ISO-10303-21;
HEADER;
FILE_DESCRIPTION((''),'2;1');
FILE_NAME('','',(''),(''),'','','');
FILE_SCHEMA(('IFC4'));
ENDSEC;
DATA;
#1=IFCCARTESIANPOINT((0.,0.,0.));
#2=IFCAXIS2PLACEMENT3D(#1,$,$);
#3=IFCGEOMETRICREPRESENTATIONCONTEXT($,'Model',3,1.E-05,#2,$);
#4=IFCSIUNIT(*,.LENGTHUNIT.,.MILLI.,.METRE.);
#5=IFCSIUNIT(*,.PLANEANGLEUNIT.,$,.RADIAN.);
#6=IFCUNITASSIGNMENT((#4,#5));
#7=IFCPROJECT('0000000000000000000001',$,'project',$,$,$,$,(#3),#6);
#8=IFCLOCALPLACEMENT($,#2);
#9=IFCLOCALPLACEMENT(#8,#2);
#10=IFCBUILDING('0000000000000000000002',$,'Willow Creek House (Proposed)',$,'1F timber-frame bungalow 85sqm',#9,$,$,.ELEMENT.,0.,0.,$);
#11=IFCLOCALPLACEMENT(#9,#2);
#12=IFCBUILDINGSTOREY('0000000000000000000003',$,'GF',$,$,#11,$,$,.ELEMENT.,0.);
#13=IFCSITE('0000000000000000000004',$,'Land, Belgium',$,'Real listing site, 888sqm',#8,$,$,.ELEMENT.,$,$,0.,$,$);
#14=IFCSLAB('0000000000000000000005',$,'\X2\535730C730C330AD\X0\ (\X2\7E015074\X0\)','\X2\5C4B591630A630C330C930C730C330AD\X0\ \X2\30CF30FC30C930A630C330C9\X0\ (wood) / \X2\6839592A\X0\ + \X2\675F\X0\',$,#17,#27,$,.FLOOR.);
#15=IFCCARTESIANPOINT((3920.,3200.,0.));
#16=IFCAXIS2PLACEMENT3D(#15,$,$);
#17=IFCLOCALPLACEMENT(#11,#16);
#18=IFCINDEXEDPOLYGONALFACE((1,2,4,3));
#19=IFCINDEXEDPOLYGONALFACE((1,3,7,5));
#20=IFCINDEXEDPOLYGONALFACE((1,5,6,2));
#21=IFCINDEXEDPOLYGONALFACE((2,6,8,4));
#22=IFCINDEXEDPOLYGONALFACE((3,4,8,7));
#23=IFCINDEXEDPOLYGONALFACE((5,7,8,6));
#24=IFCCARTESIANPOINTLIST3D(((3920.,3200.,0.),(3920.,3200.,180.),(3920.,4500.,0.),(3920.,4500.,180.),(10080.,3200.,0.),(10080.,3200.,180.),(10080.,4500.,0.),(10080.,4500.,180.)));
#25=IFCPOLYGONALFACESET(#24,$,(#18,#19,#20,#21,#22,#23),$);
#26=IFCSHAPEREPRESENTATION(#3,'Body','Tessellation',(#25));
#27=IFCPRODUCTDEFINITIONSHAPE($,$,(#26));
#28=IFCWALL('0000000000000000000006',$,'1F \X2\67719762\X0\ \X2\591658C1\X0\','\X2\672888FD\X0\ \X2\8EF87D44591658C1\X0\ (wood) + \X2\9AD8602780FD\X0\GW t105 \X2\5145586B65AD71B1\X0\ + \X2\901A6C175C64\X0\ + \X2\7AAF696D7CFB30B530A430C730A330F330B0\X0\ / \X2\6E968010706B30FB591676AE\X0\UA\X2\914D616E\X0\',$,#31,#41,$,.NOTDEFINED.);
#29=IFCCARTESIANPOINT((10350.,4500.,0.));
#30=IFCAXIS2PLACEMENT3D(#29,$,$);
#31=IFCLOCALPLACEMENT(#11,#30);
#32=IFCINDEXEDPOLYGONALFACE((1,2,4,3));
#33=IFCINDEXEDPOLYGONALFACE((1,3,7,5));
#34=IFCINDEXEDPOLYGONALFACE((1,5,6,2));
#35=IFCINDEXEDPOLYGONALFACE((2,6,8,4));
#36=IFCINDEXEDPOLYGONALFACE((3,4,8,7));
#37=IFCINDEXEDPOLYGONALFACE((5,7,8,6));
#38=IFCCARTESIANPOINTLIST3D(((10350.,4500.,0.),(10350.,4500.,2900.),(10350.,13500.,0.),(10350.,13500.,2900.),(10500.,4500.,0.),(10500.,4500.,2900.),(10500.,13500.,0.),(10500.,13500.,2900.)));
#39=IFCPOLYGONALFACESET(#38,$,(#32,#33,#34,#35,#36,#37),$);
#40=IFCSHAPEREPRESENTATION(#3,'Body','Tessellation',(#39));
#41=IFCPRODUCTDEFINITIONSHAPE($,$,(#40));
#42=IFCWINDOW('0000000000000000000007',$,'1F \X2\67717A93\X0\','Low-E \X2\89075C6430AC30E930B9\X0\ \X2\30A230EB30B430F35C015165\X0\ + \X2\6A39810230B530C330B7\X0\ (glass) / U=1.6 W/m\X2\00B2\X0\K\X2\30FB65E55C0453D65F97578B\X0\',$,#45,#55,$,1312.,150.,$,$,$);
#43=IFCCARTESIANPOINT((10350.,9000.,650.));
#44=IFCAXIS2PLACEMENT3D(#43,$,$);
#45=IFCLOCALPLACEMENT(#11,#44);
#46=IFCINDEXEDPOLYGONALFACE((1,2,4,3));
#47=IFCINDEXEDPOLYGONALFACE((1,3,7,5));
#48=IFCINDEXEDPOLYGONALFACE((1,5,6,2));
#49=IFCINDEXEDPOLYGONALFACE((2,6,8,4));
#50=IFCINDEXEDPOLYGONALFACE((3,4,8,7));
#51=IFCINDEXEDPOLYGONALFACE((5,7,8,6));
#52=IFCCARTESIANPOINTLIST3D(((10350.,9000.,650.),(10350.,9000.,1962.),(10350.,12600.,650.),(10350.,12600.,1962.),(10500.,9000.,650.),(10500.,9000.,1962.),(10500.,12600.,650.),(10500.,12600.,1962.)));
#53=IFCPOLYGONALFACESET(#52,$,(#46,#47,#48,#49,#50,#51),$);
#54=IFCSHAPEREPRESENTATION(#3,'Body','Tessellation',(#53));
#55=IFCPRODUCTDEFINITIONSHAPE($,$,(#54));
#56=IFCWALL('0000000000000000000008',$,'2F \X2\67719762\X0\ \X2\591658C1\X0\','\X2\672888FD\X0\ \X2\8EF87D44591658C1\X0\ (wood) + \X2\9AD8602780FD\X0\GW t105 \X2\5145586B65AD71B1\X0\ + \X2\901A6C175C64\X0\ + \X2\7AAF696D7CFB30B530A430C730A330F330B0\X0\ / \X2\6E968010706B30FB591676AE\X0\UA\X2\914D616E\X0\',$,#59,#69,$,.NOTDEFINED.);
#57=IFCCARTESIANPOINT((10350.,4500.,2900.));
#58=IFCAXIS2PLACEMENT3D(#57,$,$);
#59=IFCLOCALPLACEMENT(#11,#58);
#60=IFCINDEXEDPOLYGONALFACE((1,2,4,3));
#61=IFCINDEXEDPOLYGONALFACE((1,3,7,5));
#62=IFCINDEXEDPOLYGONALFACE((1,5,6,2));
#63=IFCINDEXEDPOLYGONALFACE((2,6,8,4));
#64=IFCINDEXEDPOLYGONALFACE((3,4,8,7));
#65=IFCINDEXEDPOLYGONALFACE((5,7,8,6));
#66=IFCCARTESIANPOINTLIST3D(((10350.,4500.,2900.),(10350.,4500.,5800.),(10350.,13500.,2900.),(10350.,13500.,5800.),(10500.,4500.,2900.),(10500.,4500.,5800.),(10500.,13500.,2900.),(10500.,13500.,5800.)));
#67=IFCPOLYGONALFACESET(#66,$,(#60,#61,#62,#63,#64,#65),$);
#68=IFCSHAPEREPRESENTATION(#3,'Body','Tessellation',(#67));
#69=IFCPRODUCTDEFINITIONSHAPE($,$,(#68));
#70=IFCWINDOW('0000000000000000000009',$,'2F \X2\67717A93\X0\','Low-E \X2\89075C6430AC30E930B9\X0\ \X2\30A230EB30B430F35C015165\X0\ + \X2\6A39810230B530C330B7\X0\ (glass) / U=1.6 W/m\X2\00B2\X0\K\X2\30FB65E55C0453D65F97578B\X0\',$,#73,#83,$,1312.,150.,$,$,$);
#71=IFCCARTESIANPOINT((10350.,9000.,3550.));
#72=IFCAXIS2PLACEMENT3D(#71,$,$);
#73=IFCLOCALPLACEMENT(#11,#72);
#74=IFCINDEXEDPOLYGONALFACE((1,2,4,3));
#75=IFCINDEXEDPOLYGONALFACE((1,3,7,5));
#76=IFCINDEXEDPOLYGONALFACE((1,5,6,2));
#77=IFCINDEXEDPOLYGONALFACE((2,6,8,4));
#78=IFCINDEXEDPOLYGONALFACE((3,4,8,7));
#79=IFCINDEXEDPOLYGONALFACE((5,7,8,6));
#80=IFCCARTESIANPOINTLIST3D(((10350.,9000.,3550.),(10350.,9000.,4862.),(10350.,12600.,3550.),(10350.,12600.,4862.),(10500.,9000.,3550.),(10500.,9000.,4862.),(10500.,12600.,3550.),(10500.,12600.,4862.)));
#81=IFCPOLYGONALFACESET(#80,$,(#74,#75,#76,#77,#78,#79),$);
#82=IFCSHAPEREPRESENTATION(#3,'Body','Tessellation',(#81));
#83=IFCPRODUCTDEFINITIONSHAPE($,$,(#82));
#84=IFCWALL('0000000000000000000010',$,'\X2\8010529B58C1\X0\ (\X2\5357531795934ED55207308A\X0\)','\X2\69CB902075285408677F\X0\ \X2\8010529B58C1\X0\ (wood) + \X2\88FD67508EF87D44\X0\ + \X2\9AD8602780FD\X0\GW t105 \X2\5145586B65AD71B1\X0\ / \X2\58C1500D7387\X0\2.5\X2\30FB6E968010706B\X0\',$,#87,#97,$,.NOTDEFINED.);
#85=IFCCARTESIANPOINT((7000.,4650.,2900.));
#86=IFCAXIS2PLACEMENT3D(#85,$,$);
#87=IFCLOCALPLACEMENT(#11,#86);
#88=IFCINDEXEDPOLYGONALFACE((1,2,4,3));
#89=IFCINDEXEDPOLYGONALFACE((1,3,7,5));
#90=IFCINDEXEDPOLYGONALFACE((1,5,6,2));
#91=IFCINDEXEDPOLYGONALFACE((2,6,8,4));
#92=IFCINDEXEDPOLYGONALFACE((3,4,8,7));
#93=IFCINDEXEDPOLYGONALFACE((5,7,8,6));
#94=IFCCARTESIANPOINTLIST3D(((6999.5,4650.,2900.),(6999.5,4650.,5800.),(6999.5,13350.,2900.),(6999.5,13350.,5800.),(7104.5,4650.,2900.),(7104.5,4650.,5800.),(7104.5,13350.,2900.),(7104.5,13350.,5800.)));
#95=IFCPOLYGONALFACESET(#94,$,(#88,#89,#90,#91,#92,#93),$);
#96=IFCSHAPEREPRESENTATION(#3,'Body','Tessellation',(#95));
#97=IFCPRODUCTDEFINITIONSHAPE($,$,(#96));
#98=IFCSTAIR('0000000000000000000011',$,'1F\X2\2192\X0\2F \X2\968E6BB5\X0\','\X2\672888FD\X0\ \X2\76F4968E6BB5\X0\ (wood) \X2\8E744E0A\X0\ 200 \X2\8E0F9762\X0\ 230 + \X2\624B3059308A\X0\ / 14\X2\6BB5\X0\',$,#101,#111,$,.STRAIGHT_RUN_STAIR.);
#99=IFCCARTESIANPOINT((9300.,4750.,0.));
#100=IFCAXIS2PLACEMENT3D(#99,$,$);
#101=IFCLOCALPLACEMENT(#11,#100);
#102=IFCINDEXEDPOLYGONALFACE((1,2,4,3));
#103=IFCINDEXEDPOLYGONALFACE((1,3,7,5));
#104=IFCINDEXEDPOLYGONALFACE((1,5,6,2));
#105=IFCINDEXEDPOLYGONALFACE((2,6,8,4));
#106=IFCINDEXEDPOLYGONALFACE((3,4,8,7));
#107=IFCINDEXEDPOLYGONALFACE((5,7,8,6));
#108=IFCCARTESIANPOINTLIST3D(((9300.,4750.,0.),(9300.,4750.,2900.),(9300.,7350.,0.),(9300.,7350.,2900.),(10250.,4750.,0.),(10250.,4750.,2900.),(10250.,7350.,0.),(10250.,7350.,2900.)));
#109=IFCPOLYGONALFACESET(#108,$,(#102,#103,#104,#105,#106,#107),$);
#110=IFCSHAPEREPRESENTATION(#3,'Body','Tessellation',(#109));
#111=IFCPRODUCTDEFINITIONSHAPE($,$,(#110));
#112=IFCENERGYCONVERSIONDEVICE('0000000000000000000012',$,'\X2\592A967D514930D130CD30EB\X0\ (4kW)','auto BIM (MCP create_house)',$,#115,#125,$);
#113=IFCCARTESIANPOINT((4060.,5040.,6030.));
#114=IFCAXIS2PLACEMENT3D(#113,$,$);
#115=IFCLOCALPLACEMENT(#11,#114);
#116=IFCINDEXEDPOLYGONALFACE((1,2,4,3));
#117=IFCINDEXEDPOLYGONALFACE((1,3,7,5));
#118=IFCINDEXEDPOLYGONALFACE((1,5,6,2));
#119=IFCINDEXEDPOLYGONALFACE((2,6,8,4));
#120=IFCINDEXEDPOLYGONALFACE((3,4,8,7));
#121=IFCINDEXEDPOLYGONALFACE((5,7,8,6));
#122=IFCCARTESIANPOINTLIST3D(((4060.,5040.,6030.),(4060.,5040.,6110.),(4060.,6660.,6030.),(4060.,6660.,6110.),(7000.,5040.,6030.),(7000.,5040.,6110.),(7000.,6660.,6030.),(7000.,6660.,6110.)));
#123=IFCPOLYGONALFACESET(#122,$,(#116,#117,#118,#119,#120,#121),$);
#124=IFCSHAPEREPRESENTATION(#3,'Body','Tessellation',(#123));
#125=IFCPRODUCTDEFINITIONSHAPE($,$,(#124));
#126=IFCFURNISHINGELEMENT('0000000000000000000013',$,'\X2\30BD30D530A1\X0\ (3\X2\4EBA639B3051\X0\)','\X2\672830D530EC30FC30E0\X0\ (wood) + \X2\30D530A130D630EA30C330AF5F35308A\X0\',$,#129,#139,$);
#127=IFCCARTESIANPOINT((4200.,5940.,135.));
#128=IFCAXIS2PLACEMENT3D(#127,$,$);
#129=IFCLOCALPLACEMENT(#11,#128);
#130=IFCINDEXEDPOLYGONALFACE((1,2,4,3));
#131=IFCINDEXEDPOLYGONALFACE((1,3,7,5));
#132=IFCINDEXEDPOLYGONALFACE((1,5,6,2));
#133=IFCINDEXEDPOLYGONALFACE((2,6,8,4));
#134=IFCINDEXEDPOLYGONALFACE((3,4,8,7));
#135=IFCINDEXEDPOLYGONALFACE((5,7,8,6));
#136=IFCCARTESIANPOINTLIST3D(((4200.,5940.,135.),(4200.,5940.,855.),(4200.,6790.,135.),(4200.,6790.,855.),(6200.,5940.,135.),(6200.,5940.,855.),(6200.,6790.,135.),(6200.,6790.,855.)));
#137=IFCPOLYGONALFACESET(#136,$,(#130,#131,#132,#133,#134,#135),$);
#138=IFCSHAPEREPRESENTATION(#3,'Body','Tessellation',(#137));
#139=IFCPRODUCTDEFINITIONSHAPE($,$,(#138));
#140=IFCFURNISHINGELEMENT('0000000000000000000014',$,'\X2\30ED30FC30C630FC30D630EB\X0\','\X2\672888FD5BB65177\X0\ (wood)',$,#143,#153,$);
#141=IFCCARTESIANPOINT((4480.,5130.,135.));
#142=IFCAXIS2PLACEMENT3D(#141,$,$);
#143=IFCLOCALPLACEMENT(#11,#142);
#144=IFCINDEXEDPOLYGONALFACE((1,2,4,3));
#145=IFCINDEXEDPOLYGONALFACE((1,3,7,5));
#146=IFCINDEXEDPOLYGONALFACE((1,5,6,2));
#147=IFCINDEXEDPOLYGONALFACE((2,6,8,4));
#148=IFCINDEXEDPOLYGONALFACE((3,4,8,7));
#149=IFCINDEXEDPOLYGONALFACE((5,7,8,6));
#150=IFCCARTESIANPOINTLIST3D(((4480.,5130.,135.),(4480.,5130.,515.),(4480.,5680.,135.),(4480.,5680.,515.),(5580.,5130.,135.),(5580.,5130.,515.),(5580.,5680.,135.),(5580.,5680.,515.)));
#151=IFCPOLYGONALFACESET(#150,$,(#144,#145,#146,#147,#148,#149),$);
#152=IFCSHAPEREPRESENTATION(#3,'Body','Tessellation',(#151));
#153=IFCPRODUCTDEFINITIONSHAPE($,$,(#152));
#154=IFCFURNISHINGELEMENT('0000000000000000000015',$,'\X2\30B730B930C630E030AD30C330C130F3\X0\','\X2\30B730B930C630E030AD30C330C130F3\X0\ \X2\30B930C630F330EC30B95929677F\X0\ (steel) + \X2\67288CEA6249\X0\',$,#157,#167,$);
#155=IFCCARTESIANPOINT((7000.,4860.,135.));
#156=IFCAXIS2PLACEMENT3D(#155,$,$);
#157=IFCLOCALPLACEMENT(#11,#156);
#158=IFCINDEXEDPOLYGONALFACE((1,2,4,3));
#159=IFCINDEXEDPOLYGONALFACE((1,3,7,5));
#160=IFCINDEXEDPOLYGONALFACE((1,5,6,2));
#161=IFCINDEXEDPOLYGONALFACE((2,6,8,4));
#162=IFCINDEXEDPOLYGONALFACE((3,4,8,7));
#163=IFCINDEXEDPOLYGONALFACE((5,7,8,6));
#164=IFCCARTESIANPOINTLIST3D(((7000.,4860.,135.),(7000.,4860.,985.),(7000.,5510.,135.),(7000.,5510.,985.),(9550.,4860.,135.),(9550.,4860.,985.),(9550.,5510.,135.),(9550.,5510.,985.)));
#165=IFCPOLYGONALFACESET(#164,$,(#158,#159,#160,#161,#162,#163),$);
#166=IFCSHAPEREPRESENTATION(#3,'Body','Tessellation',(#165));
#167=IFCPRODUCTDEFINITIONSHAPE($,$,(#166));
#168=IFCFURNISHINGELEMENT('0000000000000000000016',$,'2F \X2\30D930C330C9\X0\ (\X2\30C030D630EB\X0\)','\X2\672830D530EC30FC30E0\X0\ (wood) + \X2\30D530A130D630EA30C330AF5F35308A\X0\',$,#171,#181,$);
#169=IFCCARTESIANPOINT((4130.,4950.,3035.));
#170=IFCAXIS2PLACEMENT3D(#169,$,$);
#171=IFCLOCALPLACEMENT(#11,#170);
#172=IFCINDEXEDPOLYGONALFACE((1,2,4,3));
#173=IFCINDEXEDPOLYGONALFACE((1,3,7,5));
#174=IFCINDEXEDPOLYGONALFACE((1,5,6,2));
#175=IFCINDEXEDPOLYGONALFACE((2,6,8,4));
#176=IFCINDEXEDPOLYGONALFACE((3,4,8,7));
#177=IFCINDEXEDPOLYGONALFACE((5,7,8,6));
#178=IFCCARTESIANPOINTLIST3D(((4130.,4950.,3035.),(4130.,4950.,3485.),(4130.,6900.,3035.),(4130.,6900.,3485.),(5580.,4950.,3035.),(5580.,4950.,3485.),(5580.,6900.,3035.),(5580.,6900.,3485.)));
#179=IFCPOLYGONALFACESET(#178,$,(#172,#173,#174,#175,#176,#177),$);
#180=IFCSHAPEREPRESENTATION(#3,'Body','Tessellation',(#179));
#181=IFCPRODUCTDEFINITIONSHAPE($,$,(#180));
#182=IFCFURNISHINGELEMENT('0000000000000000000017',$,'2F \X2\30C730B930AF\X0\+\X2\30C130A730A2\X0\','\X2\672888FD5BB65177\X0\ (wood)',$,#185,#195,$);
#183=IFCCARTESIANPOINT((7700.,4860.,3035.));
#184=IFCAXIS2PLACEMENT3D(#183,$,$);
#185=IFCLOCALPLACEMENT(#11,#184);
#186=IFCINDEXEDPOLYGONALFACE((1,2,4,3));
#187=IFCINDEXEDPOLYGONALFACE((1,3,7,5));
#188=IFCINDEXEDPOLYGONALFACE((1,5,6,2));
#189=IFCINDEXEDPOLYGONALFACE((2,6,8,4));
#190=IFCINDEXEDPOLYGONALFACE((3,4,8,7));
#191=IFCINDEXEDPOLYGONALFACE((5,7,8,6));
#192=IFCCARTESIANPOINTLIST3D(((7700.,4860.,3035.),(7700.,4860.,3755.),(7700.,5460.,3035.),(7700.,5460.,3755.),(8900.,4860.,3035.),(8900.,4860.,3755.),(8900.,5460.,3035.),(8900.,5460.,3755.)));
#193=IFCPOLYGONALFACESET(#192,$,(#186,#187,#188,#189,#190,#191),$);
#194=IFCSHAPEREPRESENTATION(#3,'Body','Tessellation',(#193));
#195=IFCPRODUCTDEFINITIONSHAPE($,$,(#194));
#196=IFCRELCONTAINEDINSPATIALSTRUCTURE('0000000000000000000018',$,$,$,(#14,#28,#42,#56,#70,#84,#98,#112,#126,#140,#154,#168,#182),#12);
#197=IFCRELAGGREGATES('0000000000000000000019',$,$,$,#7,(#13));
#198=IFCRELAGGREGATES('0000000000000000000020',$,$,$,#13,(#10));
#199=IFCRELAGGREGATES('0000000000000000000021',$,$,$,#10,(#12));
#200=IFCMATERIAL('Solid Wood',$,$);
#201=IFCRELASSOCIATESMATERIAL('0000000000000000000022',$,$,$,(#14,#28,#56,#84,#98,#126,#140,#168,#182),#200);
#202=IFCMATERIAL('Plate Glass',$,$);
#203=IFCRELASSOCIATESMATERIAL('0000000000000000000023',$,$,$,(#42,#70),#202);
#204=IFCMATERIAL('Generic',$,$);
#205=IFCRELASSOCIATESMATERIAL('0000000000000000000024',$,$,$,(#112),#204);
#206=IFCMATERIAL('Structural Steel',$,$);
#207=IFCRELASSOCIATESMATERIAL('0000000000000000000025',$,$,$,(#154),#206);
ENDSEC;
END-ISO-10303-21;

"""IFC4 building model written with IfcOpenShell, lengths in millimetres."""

from ifc_helpers import new_model, si_unit, frame, frame_2d, origin, place, context, project, spatial, rectangle, extrude, material, element, fill, save


model = new_model("IFC4")

# Units and contexts
model_context = context("Model", 3, precision=1e-05, world=origin())
ifc_project = project(units=[si_unit("LENGTHUNIT", "METRE", prefix="MILLI"), si_unit("PLANEANGLEUNIT", "RADIAN")], contexts=[model_context])

# Site, building, storey
site_placement = place(None, origin())
site = spatial("IfcSite", under=ifc_project, at=site_placement, Name="Land, Belgium", ObjectType="Real listing site, 888sqm", CompositionType="ELEMENT", RefElevation=0.0)
building_placement = place(site_placement, origin())
building = spatial("IfcBuilding", under=site, at=building_placement, Name="Willow Creek House (Proposed)", ObjectType="1F timber-frame bungalow 85sqm", CompositionType="ELEMENT", ElevationOfRefHeight=0.0, ElevationOfTerrain=0.0)
storey_placement = place(building_placement, origin())
storey = spatial("IfcBuildingStorey", under=building, at=storey_placement, Name="GF", CompositionType="ELEMENT", Elevation=0.0)

# Slab
ifc_material_1 = material(Name="Solid Wood")
slab_placement = place(storey_placement, frame((3920.0, 3200.0, 0.0)))
element("IfcSlab", 1, at=slab_placement, inside=storey, material=ifc_material_1, Name="南デッキ (縁側)", Description="屋外ウッドデッキ ハードウッド (wood) / 根太 + 束", PredefinedType="FLOOR", context=model_context, shape_type="SweptSolid", body=[
    extrude(rectangle(XDim=6160.0, YDim=1300.0, at=frame_2d((3080.0, 650.0))), frame((3920.0, 3200.0, 0.0)), (0.0, 0.0, 1.0), 180.0),
])

# Wall, opening, window
wall_1_placement = place(storey_placement, frame((10350.0, 4500.0, 0.0)))
wall_1 = element("IfcWall", 2, at=wall_1_placement, inside=storey, material=ifc_material_1, Name="1F 東面 外壁", Description="木製 軸組外壁 (wood) + 高性能GW t105 充填断熱 + 通気層 + 窯業系サイディング / 準耐火・外皮UA配慮", PredefinedType="NOTDEFINED", context=model_context, shape_type="SweptSolid", body=[
    extrude(rectangle(XDim=150.0, YDim=9000.0, at=frame_2d((75.0, 4500.0))), frame((10350.0, 4500.0, 0.0)), (0.0, 0.0, 1.0), 2900.0),
])
opening_1_placement = place(storey_placement, frame((10350.0, 9000.0, 650.0)))
opening_1 = element("IfcOpeningElement", 3, at=opening_1_placement, cuts=wall_1, PredefinedType="NOTDEFINED", context=model_context, shape_type="SweptSolid", body=[
    extrude(rectangle(XDim=150.0, YDim=3600.0, at=frame_2d((75.0, 1800.0))), frame((10350.0, 9000.0, 650.0)), (0.0, 0.0, 1.0), 1312.0),
])
ifc_material_2 = material(Name="Plate Glass")
window_1_placement = place(storey_placement, frame((10350.0, 9000.0, 650.0)))
window_1 = element("IfcWindow", 4, at=window_1_placement, inside=storey, material=ifc_material_2, Name="1F 東窓", Description="Low-E 複層ガラス アルゴン封入 + 樹脂サッシ (glass) / U=1.6 W/m²K・日射取得型", OverallHeight=1312.0, OverallWidth=150.0, context=model_context, shape_type="SweptSolid", body=[
    extrude(rectangle(XDim=150.0, YDim=3600.0, at=frame_2d((75.0, 1800.0))), frame((10350.0, 9000.0, 650.0)), (0.0, 0.0, 1.0), 1312.0),
])
fill(opening_1, window_1)

# Wall, opening, window
wall_2_placement = place(storey_placement, frame((10350.0, 4500.0, 2900.0)))
wall_2 = element("IfcWall", 5, at=wall_2_placement, inside=storey, material=ifc_material_1, Name="2F 東面 外壁", Description="木製 軸組外壁 (wood) + 高性能GW t105 充填断熱 + 通気層 + 窯業系サイディング / 準耐火・外皮UA配慮", PredefinedType="NOTDEFINED", context=model_context, shape_type="SweptSolid", body=[
    extrude(rectangle(XDim=150.0, YDim=9000.0, at=frame_2d((75.0, 4500.0))), frame((10350.0, 4500.0, 2900.0)), (0.0, 0.0, 1.0), 2900.0),
])
opening_2_placement = place(storey_placement, frame((10350.0, 9000.0, 3550.0)))
opening_2 = element("IfcOpeningElement", 6, at=opening_2_placement, cuts=wall_2, PredefinedType="NOTDEFINED", context=model_context, shape_type="SweptSolid", body=[
    extrude(rectangle(XDim=150.0, YDim=3600.0, at=frame_2d((75.0, 1800.0))), frame((10350.0, 9000.0, 3550.0)), (0.0, 0.0, 1.0), 1312.0),
])
window_2_placement = place(storey_placement, frame((10350.0, 9000.0, 3550.0)))
window_2 = element("IfcWindow", 7, at=window_2_placement, inside=storey, material=ifc_material_2, Name="2F 東窓", Description="Low-E 複層ガラス アルゴン封入 + 樹脂サッシ (glass) / U=1.6 W/m²K・日射取得型", OverallHeight=1312.0, OverallWidth=150.0, context=model_context, shape_type="SweptSolid", body=[
    extrude(rectangle(XDim=150.0, YDim=3600.0, at=frame_2d((75.0, 1800.0))), frame((10350.0, 9000.0, 3550.0)), (0.0, 0.0, 1.0), 1312.0),
])
fill(opening_2, window_2)

# Wall
wall_3_placement = place(storey_placement, frame((7000.0, 4650.0, 2900.0)))
element("IfcWall", 8, at=wall_3_placement, inside=storey, material=ifc_material_1, Name="耐力壁 (南北間仕切り)", Description="構造用合板 耐力壁 (wood) + 製材軸組 + 高性能GW t105 充填断熱 / 壁倍率2.5・準耐火", PredefinedType="NOTDEFINED", context=model_context, shape_type="SweptSolid", body=[
    extrude(rectangle(XDim=105.0, YDim=8700.0, at=frame_2d((52.0, 4350.0))), frame((7000.0, 4650.0, 2900.0)), (0.0, 0.0, 1.0), 2900.0),
])

# Stair
stair_placement = place(storey_placement, frame((9300.0, 4750.0, 0.0)))
element("IfcStair", 9, at=stair_placement, inside=storey, material=ifc_material_1, Name="1F→2F 階段", Description="木製 直階段 (wood) 蹴上 200 踏面 230 + 手すり / 14段", PredefinedType="STRAIGHT_RUN_STAIR", context=model_context, shape_type="SweptSolid", body=[
    extrude(rectangle(XDim=950.0, YDim=2600.0, at=frame_2d((475.0, 1300.0))), frame((9300.0, 4750.0, 0.0)), (0.0, 0.0, 1.0), 2900.0),
])

# Energy conversion device
ifc_material_3 = material(Name="Generic")
energy_conversion_device_placement = place(storey_placement, frame((4060.0, 5040.0, 6030.0)))
element("IfcEnergyConversionDevice", 10, at=energy_conversion_device_placement, inside=storey, material=ifc_material_3, Name="太陽光パネル (4kW)", Description="auto BIM (MCP create_house)", context=model_context, shape_type="SweptSolid", body=[
    extrude(rectangle(XDim=2940.0, YDim=1620.0, at=frame_2d((1470.0, 810.0))), frame((4060.0, 5040.0, 6030.0)), (0.0, 0.0, 1.0), 80.0),
])

# Furnishing elements
furnishing_1_placement = place(storey_placement, frame((4200.0, 5940.0, 135.0)))
element("IfcFurnishingElement", 11, at=furnishing_1_placement, inside=storey, material=ifc_material_1, Name="ソファ (3人掛け)", Description="木フレーム (wood) + ファブリック張り", context=model_context, shape_type="SweptSolid", body=[
    extrude(rectangle(XDim=2000.0, YDim=850.0, at=frame_2d((1000.0, 425.0))), frame((4200.0, 5940.0, 135.0)), (0.0, 0.0, 1.0), 720.0),
])
furnishing_2_placement = place(storey_placement, frame((4480.0, 5130.0, 135.0)))
element("IfcFurnishingElement", 12, at=furnishing_2_placement, inside=storey, material=ifc_material_1, Name="ローテーブル", Description="木製家具 (wood)", context=model_context, shape_type="SweptSolid", body=[
    extrude(rectangle(XDim=1100.0, YDim=550.0, at=frame_2d((550.0, 275.0))), frame((4480.0, 5130.0, 135.0)), (0.0, 0.0, 1.0), 380.0),
])
ifc_material_4 = material(Name="Structural Steel")
furnishing_3_placement = place(storey_placement, frame((7000.0, 4860.0, 135.0)))
element("IfcFurnishingElement", 13, at=furnishing_3_placement, inside=storey, material=ifc_material_4, Name="システムキッチン", Description="システムキッチン ステンレス天板 (steel) + 木質扉", context=model_context, shape_type="SweptSolid", body=[
    extrude(rectangle(XDim=2550.0, YDim=650.0, at=frame_2d((1275.0, 325.0))), frame((7000.0, 4860.0, 135.0)), (0.0, 0.0, 1.0), 850.0),
])
furnishing_4_placement = place(storey_placement, frame((4130.0, 4950.0, 3035.0)))
element("IfcFurnishingElement", 14, at=furnishing_4_placement, inside=storey, material=ifc_material_1, Name="2F ベッド (ダブル)", Description="木フレーム (wood) + ファブリック張り", context=model_context, shape_type="SweptSolid", body=[
    extrude(rectangle(XDim=1450.0, YDim=1950.0, at=frame_2d((725.0, 975.0))), frame((4130.0, 4950.0, 3035.0)), (0.0, 0.0, 1.0), 450.0),
])
furnishing_5_placement = place(storey_placement, frame((7700.0, 4860.0, 3035.0)))
element("IfcFurnishingElement", 15, at=furnishing_5_placement, inside=storey, material=ifc_material_1, Name="2F デスク+チェア", Description="木製家具 (wood)", context=model_context, shape_type="SweptSolid", body=[
    extrude(rectangle(XDim=1200.0, YDim=600.0, at=frame_2d((600.0, 300.0))), frame((7700.0, 4860.0, 3035.0)), (0.0, 0.0, 1.0), 720.0),
])

save(model, "model.ifc")
